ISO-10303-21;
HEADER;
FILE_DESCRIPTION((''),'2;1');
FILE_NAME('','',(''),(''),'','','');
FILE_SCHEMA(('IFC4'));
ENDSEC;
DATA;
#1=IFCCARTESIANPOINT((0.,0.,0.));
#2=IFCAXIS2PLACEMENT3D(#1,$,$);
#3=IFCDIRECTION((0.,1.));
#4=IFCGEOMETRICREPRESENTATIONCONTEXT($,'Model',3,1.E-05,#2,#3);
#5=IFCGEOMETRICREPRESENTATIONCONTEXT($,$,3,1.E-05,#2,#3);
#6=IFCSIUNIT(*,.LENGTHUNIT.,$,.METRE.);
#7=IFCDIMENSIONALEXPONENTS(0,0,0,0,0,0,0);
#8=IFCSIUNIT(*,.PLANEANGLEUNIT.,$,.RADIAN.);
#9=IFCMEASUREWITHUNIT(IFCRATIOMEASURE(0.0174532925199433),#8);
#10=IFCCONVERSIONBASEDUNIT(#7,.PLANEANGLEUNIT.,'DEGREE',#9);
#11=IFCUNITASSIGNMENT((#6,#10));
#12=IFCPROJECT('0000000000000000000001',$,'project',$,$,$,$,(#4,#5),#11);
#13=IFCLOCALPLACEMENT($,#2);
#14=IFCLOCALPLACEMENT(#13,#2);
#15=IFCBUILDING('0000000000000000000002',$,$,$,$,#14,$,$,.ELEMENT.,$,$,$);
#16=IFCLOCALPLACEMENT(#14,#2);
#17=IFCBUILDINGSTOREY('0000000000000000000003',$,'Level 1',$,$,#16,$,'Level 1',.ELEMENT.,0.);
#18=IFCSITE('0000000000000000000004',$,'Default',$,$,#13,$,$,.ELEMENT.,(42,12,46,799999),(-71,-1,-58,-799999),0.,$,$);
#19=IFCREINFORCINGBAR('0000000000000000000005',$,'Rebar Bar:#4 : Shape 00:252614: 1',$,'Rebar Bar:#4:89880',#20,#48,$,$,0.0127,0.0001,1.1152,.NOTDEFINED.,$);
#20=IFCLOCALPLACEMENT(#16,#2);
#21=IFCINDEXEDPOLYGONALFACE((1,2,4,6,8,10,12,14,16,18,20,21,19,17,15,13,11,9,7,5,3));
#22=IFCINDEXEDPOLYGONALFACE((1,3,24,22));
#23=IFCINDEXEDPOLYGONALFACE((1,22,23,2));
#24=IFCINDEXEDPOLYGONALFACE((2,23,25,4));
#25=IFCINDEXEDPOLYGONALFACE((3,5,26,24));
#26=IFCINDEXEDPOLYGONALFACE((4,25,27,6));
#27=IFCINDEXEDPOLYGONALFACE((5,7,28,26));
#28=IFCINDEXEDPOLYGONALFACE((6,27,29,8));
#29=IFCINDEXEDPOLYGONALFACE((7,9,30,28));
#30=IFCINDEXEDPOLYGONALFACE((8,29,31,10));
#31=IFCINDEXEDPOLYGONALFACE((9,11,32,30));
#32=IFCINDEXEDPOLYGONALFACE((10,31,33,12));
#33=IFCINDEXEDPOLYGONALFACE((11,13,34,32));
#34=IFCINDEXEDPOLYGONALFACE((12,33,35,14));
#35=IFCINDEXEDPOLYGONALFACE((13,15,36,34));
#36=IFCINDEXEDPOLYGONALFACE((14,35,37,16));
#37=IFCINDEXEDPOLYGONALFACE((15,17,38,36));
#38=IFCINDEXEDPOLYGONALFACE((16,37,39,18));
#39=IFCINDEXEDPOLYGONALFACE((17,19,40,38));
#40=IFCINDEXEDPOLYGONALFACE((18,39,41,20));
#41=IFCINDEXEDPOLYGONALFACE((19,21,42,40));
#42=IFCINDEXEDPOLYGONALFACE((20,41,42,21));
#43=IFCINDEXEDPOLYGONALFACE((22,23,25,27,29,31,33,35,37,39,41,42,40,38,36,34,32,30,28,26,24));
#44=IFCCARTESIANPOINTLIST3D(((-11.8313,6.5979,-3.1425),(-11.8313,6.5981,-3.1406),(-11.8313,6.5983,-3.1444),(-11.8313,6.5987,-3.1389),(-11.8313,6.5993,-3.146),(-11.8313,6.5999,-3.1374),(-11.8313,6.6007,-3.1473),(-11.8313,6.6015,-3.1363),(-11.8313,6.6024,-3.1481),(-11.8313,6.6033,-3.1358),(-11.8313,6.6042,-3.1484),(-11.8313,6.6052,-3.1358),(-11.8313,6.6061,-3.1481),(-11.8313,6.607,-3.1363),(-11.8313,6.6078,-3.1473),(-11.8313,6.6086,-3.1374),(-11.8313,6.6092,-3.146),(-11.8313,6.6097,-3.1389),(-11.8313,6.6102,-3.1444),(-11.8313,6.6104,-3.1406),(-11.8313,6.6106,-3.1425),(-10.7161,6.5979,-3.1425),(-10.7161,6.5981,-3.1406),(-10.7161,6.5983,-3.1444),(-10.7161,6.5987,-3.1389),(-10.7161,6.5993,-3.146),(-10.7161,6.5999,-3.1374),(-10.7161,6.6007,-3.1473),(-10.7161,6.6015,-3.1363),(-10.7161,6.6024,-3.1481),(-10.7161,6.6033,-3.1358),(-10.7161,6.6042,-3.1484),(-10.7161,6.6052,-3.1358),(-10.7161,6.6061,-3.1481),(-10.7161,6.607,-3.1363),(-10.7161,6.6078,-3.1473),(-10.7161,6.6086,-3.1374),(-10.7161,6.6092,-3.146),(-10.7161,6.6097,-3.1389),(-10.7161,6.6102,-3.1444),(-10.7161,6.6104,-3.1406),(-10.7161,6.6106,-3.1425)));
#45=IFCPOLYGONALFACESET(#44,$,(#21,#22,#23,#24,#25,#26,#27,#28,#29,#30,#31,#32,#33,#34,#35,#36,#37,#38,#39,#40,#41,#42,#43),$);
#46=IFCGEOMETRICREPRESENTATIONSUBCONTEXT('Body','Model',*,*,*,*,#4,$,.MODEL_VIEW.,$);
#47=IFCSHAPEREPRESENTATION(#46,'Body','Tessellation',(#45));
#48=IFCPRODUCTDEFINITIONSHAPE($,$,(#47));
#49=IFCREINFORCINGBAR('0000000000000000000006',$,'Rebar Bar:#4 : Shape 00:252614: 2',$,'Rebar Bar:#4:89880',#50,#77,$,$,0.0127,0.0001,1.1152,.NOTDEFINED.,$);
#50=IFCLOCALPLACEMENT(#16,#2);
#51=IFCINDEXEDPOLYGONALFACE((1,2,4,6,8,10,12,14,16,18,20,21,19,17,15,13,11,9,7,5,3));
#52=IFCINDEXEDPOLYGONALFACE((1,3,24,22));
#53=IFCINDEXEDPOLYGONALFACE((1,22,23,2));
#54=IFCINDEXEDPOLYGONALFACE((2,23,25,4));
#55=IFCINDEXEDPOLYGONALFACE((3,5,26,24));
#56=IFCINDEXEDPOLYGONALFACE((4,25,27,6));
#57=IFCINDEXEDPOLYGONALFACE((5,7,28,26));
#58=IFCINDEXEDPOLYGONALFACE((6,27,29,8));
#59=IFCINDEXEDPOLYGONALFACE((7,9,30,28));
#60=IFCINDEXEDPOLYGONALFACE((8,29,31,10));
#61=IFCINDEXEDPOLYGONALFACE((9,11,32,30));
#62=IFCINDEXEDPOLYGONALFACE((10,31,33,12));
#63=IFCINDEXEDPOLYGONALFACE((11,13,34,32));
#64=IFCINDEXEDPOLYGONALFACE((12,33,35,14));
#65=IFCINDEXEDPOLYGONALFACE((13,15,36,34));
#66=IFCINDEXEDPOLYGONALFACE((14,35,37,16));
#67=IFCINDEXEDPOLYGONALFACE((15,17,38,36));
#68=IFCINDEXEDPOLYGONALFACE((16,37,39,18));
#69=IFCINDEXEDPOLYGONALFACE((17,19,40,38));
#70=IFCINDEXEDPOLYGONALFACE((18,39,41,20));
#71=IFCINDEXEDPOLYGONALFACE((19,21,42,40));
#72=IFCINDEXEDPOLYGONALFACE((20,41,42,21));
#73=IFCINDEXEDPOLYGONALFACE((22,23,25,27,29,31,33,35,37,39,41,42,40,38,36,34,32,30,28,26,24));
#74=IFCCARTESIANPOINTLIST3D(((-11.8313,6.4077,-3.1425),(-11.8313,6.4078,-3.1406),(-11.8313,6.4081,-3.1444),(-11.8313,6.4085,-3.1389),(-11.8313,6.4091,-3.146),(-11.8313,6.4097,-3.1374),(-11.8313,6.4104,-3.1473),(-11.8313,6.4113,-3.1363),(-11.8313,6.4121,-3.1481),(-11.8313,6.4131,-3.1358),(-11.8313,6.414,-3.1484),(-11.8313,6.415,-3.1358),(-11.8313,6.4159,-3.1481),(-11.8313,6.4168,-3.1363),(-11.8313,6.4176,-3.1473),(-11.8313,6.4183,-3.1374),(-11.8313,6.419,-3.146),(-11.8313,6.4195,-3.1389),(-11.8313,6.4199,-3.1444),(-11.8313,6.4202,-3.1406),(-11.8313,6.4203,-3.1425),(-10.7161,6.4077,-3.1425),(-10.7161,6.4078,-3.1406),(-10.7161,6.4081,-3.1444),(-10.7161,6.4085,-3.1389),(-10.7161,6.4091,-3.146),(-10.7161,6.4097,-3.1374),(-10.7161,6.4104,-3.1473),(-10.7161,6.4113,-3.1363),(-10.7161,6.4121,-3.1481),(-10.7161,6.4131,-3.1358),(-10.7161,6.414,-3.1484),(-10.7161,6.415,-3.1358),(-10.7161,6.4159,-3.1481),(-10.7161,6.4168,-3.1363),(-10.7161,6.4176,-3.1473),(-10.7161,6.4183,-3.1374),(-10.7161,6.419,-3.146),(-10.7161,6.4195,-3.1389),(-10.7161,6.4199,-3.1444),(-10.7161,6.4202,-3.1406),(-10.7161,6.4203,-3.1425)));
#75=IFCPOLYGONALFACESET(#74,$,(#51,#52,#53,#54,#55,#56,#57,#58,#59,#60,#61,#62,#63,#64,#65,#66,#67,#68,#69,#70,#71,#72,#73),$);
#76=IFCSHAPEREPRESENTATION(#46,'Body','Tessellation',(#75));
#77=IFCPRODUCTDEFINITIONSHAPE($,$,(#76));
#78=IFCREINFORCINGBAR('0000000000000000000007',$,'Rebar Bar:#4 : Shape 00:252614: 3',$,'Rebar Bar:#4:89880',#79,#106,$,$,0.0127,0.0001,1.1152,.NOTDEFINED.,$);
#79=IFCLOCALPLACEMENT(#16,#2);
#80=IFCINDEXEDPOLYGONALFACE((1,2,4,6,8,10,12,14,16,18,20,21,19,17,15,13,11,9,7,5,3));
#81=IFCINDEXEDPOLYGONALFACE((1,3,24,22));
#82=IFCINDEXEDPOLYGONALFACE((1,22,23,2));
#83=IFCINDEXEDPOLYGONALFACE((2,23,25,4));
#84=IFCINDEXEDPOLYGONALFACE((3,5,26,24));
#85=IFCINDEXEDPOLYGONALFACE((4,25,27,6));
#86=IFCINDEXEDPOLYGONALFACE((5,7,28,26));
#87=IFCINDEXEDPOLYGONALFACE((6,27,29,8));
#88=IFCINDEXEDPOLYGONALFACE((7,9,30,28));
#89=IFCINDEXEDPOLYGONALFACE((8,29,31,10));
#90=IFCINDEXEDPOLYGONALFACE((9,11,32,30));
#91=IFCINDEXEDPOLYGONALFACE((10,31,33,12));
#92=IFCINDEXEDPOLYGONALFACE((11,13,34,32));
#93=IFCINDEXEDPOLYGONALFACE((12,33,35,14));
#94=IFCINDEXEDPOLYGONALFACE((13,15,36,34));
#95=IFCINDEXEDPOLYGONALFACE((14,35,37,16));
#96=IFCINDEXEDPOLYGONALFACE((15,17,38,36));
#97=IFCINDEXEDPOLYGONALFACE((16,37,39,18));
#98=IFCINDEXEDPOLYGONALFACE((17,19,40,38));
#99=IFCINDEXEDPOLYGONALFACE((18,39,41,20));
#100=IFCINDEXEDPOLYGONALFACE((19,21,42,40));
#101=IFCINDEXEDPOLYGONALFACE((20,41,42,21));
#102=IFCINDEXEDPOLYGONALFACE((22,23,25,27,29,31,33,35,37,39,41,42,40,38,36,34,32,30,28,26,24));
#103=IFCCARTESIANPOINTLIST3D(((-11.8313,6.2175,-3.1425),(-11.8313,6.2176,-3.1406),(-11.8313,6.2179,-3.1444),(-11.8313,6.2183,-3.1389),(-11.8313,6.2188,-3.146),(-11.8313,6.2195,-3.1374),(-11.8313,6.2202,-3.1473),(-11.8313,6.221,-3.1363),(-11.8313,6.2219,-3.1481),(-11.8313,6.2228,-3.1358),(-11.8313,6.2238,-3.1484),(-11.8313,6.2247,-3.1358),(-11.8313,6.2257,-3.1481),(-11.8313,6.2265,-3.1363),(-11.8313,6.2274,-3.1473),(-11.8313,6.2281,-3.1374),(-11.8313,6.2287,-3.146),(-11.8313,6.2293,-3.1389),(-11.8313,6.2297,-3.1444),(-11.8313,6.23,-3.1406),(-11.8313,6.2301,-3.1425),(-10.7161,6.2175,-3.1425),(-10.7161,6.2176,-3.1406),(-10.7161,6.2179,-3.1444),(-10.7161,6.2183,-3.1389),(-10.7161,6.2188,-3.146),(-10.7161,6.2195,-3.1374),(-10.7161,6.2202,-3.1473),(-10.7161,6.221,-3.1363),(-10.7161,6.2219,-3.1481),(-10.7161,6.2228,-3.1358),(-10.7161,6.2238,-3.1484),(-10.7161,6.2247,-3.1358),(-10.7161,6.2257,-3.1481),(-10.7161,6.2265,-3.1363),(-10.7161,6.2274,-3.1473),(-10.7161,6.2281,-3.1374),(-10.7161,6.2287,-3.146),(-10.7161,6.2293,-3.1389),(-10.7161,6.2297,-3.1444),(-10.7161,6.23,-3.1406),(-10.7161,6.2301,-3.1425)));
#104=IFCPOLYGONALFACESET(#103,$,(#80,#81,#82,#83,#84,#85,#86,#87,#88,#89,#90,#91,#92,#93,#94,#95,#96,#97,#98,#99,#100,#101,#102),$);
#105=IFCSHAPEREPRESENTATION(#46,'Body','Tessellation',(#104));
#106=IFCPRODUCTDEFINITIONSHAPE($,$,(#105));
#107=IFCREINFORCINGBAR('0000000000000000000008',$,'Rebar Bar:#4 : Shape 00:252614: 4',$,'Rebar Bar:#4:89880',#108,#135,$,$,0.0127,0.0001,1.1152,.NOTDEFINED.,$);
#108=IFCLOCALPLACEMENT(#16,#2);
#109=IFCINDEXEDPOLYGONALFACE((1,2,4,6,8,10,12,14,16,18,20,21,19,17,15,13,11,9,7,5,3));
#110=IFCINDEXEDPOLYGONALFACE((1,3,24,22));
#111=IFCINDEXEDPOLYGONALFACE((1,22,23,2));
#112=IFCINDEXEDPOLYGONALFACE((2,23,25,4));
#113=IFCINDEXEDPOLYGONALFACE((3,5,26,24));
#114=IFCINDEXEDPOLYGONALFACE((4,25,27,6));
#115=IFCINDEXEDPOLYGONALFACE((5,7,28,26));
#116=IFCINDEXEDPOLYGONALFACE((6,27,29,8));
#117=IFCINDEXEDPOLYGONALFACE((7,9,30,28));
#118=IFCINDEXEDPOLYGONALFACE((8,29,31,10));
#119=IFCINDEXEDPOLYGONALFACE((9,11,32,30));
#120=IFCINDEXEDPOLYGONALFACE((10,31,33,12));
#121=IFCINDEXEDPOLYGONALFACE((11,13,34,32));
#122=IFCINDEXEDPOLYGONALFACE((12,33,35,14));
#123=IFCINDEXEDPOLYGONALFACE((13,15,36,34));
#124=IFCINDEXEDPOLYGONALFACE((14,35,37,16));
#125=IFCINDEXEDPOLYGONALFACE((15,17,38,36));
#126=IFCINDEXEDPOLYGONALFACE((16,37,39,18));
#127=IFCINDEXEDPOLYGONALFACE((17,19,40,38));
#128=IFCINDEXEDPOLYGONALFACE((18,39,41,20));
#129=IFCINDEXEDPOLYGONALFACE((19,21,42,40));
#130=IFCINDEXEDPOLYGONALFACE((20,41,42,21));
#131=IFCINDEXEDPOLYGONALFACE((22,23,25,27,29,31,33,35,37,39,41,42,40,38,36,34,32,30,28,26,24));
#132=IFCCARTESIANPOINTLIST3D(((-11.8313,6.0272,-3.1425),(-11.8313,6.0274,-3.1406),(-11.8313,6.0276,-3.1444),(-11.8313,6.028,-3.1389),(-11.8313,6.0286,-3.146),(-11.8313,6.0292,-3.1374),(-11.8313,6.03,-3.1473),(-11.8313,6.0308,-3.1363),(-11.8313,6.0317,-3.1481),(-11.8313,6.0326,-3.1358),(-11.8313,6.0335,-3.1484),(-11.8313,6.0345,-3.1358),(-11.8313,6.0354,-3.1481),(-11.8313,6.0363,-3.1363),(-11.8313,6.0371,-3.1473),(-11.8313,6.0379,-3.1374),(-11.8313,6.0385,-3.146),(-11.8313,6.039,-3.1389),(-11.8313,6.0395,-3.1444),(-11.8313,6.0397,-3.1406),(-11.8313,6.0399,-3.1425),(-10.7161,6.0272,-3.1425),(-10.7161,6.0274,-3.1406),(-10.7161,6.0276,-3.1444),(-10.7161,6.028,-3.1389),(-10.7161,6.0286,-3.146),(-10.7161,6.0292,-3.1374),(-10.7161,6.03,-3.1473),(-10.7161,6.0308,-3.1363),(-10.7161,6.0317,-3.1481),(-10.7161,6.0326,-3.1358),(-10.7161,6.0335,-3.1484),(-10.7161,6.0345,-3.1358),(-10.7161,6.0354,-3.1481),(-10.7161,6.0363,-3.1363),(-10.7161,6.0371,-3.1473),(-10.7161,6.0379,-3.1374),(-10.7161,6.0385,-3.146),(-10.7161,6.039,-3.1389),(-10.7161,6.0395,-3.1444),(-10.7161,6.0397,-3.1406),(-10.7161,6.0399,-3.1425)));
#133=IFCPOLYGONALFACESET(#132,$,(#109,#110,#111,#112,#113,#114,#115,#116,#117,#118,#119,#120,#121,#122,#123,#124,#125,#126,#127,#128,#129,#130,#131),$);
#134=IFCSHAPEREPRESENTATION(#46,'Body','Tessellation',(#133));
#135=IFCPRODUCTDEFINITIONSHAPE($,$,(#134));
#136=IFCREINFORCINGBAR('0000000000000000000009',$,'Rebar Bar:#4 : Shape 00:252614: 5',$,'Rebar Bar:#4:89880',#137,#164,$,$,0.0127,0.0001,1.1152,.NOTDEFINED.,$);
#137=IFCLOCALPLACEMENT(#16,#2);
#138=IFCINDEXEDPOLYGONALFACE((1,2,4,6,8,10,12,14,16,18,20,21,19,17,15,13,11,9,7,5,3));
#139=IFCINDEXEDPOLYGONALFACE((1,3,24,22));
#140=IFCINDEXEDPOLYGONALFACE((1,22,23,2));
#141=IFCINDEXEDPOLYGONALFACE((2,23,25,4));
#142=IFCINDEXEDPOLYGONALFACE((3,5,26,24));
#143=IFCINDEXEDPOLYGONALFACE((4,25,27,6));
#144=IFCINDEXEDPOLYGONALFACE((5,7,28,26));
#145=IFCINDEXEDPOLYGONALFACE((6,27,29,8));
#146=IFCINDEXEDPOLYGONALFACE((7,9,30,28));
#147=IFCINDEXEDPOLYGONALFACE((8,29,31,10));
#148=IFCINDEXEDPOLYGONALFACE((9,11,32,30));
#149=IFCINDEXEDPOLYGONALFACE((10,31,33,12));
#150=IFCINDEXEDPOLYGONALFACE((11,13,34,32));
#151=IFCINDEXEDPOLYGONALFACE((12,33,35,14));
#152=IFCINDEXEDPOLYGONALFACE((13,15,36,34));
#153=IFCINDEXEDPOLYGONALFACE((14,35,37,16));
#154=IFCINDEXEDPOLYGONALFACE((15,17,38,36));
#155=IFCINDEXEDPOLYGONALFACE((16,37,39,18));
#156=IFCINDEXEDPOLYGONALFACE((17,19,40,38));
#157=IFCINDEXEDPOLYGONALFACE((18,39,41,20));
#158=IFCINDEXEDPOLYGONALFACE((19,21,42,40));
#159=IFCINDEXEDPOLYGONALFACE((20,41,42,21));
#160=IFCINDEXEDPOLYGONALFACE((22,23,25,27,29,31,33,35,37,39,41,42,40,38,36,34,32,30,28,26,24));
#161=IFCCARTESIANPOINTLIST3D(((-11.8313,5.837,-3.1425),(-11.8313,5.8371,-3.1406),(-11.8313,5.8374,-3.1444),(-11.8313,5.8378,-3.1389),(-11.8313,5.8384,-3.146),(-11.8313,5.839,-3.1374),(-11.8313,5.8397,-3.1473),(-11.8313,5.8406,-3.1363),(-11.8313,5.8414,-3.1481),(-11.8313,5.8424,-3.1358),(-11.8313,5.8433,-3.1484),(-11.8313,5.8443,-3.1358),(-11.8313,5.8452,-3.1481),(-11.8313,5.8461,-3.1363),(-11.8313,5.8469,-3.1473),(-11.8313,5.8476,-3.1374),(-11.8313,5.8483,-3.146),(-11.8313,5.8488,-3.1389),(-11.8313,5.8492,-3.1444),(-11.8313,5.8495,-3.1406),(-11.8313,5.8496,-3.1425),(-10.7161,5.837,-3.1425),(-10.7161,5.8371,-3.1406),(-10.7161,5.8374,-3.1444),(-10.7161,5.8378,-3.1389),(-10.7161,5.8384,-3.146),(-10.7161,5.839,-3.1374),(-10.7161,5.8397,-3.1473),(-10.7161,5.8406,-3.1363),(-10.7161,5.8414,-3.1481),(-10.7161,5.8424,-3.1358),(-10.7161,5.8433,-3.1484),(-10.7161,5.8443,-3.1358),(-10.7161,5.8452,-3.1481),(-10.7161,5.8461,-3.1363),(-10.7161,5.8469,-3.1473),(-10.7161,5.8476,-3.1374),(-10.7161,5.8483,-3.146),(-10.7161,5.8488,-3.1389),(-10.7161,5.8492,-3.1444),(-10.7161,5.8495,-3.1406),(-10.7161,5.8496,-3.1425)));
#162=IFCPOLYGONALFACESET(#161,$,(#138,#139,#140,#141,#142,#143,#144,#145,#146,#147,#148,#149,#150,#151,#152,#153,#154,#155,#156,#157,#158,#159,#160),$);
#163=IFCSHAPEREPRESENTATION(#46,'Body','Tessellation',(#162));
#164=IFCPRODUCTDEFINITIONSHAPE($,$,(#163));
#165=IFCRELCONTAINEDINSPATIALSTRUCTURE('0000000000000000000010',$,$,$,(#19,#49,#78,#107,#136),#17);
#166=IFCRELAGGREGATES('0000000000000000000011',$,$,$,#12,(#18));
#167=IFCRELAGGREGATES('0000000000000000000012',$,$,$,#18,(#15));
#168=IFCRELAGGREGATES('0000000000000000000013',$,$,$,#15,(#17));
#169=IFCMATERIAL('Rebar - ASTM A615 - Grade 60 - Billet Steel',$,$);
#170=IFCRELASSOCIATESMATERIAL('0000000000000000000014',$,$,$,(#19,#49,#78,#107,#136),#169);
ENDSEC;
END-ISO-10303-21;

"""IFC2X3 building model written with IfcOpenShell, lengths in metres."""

from ifc_helpers import new_model, entity, si_unit, converted_unit, direction, origin, place, context, subcontext, project, spatial, material, element, save


model = new_model("IFC2X3")

# Units and contexts
model_context = context("Model", 3, precision=1e-05, world=origin(), true_north=direction((0.0, 1.0)))
context_of_model = context(None, 3, precision=1e-05, world=origin(), true_north=direction((0.0, 1.0)))
body_context = subcontext(model_context, "Body", "Model", "MODEL_VIEW")
ifc_project = project(units=[si_unit("LENGTHUNIT", "METRE"), converted_unit("PLANEANGLEUNIT", "DEGREE", entity("IfcRatioMeasure", 0.0174532925199433), si_unit("PLANEANGLEUNIT", "RADIAN"), dimensions=[0, 0, 0, 0, 0, 0, 0])], contexts=[model_context, context_of_model])

# Site, building, storey
site_placement = place(None, origin())
site = spatial("IfcSite", under=ifc_project, at=site_placement, Name="Default", CompositionType="ELEMENT", RefLatitude=(42, 12, 46, 799999), RefLongitude=(-71, -1, -58, -799999), RefElevation=0.0)
building_placement = place(site_placement, origin())
building = spatial("IfcBuilding", under=site, at=building_placement, CompositionType="ELEMENT")
storey_placement = place(building_placement, origin())
storey = spatial("IfcBuildingStorey", under=building, at=storey_placement, Name="Level 1", LongName="Level 1", CompositionType="ELEMENT", Elevation=0.0)

# Reinforcing bars
ifc_material_1 = material(Name="Rebar - ASTM A615 - Grade 60 - Billet Steel")
reinforcing_bar_1_placement = place(storey_placement, origin())
element("IfcReinforcingBar", 1, at=reinforcing_bar_1_placement, inside=storey, material=ifc_material_1, Name="Rebar Bar:#4 : Shape 00:252614: 1", ObjectType="Rebar Bar:#4:89880", BarLength=1.1152, BarRole="NOTDEFINED", CrossSectionArea=0.0001, NominalDiameter=0.0127, context=body_context, shape_type="AdvancedSweptSolid", body=[
    entity("IfcSweptDiskSolid", entity("IfcCompositeCurve", [entity("IfcCompositeCurveSegment", "CONTINUOUS", True, entity("IfcPolyline", [entity("IfcCartesianPoint", [-10.7161, 6.6042, -3.142]), entity("IfcCartesianPoint", [-11.8313, 6.6042, -3.142])]))], False), 0.0063, None, 0.0, 1.0),
])
reinforcing_bar_2_placement = place(storey_placement, origin())
element("IfcReinforcingBar", 2, at=reinforcing_bar_2_placement, inside=storey, material=ifc_material_1, Name="Rebar Bar:#4 : Shape 00:252614: 2", ObjectType="Rebar Bar:#4:89880", BarLength=1.1152, BarRole="NOTDEFINED", CrossSectionArea=0.0001, NominalDiameter=0.0127, context=body_context, shape_type="AdvancedSweptSolid", body=[
    entity("IfcSweptDiskSolid", entity("IfcCompositeCurve", [entity("IfcCompositeCurveSegment", "CONTINUOUS", True, entity("IfcPolyline", [entity("IfcCartesianPoint", [-10.7161, 6.414, -3.142]), entity("IfcCartesianPoint", [-11.8313, 6.414, -3.142])]))], False), 0.0063, None, 0.0, 1.0),
])
reinforcing_bar_3_placement = place(storey_placement, origin())
element("IfcReinforcingBar", 3, at=reinforcing_bar_3_placement, inside=storey, material=ifc_material_1, Name="Rebar Bar:#4 : Shape 00:252614: 3", ObjectType="Rebar Bar:#4:89880", BarLength=1.1152, BarRole="NOTDEFINED", CrossSectionArea=0.0001, NominalDiameter=0.0127, context=body_context, shape_type="AdvancedSweptSolid", body=[
    entity("IfcSweptDiskSolid", entity("IfcCompositeCurve", [entity("IfcCompositeCurveSegment", "CONTINUOUS", True, entity("IfcPolyline", [entity("IfcCartesianPoint", [-10.7161, 6.2238, -3.142]), entity("IfcCartesianPoint", [-11.8313, 6.2238, -3.142])]))], False), 0.0063, None, 0.0, 1.0),
])
reinforcing_bar_4_placement = place(storey_placement, origin())
element("IfcReinforcingBar", 4, at=reinforcing_bar_4_placement, inside=storey, material=ifc_material_1, Name="Rebar Bar:#4 : Shape 00:252614: 4", ObjectType="Rebar Bar:#4:89880", BarLength=1.1152, BarRole="NOTDEFINED", CrossSectionArea=0.0001, NominalDiameter=0.0127, context=body_context, shape_type="AdvancedSweptSolid", body=[
    entity("IfcSweptDiskSolid", entity("IfcCompositeCurve", [entity("IfcCompositeCurveSegment", "CONTINUOUS", True, entity("IfcPolyline", [entity("IfcCartesianPoint", [-10.7161, 6.0335, -3.142]), entity("IfcCartesianPoint", [-11.8313, 6.0335, -3.142])]))], False), 0.0063, None, 0.0, 1.0),
])
reinforcing_bar_5_placement = place(storey_placement, origin())
element("IfcReinforcingBar", 5, at=reinforcing_bar_5_placement, inside=storey, material=ifc_material_1, Name="Rebar Bar:#4 : Shape 00:252614: 5", ObjectType="Rebar Bar:#4:89880", BarLength=1.1152, BarRole="NOTDEFINED", CrossSectionArea=0.0001, NominalDiameter=0.0127, context=body_context, shape_type="AdvancedSweptSolid", body=[
    entity("IfcSweptDiskSolid", entity("IfcCompositeCurve", [entity("IfcCompositeCurveSegment", "CONTINUOUS", True, entity("IfcPolyline", [entity("IfcCartesianPoint", [-10.7161, 5.8433, -3.142]), entity("IfcCartesianPoint", [-11.8313, 5.8433, -3.142])]))], False), 0.0063, None, 0.0, 1.0),
])

save(model, "model.ifc")
